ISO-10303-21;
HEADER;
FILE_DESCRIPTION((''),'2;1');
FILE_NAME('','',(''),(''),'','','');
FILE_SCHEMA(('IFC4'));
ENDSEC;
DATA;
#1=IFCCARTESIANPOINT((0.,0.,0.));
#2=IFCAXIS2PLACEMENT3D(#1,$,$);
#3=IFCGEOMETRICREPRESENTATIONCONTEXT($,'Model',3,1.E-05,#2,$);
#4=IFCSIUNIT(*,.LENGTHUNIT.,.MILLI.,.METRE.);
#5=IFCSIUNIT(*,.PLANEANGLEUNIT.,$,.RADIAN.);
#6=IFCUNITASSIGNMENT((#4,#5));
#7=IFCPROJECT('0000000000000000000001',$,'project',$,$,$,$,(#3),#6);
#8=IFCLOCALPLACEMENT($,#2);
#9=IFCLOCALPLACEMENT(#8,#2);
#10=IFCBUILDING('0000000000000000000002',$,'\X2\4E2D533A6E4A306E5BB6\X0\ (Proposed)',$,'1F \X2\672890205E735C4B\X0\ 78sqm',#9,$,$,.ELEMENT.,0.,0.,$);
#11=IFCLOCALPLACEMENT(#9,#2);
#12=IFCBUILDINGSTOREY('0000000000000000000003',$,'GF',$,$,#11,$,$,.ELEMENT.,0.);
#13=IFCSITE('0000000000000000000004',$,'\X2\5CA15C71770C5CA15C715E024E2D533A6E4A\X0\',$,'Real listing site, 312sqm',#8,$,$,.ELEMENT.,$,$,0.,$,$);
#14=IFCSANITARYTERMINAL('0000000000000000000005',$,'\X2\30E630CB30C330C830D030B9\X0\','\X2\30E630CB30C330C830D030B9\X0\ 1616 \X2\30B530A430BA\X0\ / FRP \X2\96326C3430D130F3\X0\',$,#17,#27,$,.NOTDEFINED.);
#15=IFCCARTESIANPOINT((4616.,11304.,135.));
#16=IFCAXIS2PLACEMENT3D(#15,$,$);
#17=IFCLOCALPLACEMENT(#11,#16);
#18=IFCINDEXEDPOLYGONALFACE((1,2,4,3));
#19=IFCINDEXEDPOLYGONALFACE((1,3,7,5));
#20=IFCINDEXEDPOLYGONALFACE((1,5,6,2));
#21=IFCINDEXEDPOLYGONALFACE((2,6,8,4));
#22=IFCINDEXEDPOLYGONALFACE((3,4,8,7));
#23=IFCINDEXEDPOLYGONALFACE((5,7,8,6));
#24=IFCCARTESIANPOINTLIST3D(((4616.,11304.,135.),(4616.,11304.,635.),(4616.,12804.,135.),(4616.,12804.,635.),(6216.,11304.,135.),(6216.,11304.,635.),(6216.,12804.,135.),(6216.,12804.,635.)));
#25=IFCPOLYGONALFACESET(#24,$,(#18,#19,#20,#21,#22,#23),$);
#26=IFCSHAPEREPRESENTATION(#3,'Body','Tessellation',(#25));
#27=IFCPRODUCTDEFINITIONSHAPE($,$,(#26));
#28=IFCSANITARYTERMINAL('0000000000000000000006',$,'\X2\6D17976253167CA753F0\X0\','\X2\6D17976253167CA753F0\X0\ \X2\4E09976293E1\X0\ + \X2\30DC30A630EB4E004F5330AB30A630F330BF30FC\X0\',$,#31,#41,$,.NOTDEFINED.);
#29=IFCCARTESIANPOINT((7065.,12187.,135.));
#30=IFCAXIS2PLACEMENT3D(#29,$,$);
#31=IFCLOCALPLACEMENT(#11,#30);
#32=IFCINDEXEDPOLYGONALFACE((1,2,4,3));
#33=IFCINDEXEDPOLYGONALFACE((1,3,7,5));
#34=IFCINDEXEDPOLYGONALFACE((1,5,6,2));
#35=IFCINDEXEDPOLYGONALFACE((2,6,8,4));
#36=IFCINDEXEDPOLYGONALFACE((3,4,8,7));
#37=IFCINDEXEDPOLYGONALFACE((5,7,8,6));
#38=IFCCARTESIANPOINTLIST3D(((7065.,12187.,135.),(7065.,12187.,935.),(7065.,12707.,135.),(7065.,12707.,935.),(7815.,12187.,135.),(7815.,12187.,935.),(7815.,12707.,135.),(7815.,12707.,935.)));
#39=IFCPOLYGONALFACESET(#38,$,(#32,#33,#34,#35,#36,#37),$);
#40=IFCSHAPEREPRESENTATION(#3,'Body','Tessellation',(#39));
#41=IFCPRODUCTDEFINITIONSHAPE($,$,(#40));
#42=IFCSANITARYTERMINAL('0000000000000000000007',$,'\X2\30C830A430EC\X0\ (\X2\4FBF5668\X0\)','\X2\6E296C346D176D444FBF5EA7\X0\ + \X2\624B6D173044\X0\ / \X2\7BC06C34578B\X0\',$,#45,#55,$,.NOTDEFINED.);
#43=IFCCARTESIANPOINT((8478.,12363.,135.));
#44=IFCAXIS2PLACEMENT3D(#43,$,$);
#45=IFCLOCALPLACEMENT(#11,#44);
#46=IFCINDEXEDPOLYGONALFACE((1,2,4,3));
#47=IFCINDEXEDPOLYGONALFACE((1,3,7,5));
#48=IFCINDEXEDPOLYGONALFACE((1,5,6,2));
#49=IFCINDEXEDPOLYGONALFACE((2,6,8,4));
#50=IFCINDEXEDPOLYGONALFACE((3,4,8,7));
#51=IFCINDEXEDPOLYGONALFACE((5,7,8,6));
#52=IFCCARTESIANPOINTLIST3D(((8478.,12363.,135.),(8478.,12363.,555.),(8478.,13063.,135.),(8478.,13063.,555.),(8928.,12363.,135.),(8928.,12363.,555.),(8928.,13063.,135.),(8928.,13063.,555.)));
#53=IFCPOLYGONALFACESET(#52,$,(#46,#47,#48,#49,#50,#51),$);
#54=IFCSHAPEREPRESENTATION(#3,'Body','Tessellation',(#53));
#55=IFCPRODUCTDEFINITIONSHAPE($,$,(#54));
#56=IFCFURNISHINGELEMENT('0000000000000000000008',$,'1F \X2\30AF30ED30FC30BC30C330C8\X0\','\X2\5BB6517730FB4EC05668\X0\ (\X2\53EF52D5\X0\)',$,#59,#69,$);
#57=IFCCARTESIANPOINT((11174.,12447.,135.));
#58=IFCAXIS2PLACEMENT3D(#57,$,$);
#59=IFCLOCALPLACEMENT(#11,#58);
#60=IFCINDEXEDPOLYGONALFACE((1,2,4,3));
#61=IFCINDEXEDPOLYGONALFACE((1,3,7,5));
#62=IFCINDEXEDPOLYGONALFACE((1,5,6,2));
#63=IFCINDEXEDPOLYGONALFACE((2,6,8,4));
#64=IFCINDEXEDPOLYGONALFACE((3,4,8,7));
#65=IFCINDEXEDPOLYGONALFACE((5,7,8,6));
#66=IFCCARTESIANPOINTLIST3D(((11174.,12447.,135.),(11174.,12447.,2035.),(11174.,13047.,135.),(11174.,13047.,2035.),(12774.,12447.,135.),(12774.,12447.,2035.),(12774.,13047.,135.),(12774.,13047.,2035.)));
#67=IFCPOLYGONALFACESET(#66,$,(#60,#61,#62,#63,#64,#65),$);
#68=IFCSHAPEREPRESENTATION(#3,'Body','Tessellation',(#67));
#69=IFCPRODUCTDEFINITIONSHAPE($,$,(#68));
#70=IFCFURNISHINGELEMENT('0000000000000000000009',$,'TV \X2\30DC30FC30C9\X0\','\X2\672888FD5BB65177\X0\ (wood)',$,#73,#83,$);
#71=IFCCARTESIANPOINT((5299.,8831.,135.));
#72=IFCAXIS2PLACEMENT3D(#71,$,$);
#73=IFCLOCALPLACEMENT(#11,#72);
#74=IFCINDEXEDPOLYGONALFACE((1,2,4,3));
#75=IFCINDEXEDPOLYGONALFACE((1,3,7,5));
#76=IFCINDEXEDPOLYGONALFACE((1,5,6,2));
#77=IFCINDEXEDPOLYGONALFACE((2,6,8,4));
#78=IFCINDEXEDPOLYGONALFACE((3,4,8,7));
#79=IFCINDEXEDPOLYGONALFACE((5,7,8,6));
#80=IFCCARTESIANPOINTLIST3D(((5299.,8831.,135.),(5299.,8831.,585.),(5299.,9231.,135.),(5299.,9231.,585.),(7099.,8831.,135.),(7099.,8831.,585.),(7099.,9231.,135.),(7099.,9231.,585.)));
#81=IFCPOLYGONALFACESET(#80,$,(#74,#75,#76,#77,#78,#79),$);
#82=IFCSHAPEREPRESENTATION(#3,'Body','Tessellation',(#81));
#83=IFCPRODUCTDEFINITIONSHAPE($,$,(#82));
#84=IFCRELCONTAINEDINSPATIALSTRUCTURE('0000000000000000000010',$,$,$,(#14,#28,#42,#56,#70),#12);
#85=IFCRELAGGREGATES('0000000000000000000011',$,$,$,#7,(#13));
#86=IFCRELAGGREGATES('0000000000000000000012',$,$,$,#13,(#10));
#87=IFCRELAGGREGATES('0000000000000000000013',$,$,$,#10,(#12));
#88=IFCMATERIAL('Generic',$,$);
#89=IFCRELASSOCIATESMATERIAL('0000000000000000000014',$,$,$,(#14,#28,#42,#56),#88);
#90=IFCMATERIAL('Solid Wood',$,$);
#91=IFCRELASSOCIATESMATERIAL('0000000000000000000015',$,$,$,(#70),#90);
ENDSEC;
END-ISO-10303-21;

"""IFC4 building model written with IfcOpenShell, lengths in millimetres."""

from ifc_helpers import new_model, si_unit, frame, frame_2d, origin, place, context, project, spatial, rectangle, extrude, material, element, save


model = new_model("IFC4")

# Units and contexts
model_context = context("Model", 3, precision=1e-05, world=origin())
ifc_project = project(units=[si_unit("LENGTHUNIT", "METRE", prefix="MILLI"), si_unit("PLANEANGLEUNIT", "RADIAN")], contexts=[model_context])

# Site, building, storey
site_placement = place(None, origin())
site = spatial("IfcSite", under=ifc_project, at=site_placement, Name="岡山県岡山市中区湊", ObjectType="Real listing site, 312sqm", CompositionType="ELEMENT", RefElevation=0.0)
building_placement = place(site_placement, origin())
building = spatial("IfcBuilding", under=site, at=building_placement, Name="中区湊の家 (Proposed)", ObjectType="1F 木造平屋 78sqm", CompositionType="ELEMENT", ElevationOfRefHeight=0.0, ElevationOfTerrain=0.0)
storey_placement = place(building_placement, origin())
storey = spatial("IfcBuildingStorey", under=building, at=storey_placement, Name="GF", CompositionType="ELEMENT", Elevation=0.0)

# Shared definitions
ifc_material_1 = material(Name="Solid Wood")

# Sanitary terminals
ifc_material_2 = material(Name="Generic")
sanitary_terminal_1_placement = place(storey_placement, frame((4616.0, 11304.0, 135.0)))
element("IfcSanitaryTerminal", 1, at=sanitary_terminal_1_placement, inside=storey, material=ifc_material_2, Name="ユニットバス", Description="ユニットバス 1616 サイズ / FRP 防水パン", PredefinedType="NOTDEFINED", context=model_context, shape_type="SweptSolid", body=[
    extrude(rectangle(XDim=1600.0, YDim=1500.0, at=frame_2d((800.0, 750.0))), frame((4616.0, 11304.0, 135.0)), (0.0, 0.0, 1.0), 500.0),
])
sanitary_terminal_2_placement = place(storey_placement, frame((7065.0, 12187.0, 135.0)))
element("IfcSanitaryTerminal", 2, at=sanitary_terminal_2_placement, inside=storey, material=ifc_material_2, Name="洗面化粧台", Description="洗面化粧台 三面鏡 + ボウル一体カウンター", PredefinedType="NOTDEFINED", context=model_context, shape_type="SweptSolid", body=[
    extrude(rectangle(XDim=750.0, YDim=520.0, at=frame_2d((375.0, 260.0))), frame((7065.0, 12187.0, 135.0)), (0.0, 0.0, 1.0), 800.0),
])
sanitary_terminal_3_placement = place(storey_placement, frame((8478.0, 12363.0, 135.0)))
element("IfcSanitaryTerminal", 3, at=sanitary_terminal_3_placement, inside=storey, material=ifc_material_2, Name="トイレ (便器)", Description="温水洗浄便座 + 手洗い / 節水型", PredefinedType="NOTDEFINED", context=model_context, shape_type="SweptSolid", body=[
    extrude(rectangle(XDim=450.0, YDim=700.0, at=frame_2d((225.0, 350.0))), frame((8478.0, 12363.0, 135.0)), (0.0, 0.0, 1.0), 420.0),
])

# Furnishing elements
furnishing_1_placement = place(storey_placement, frame((11174.0, 12447.0, 135.0)))
element("IfcFurnishingElement", 4, at=furnishing_1_placement, inside=storey, material=ifc_material_2, Name="1F クローゼット", Description="家具・什器 (可動)", context=model_context, shape_type="SweptSolid", body=[
    extrude(rectangle(XDim=1600.0, YDim=600.0, at=frame_2d((800.0, 300.0))), frame((11174.0, 12447.0, 135.0)), (0.0, 0.0, 1.0), 1900.0),
])
furnishing_2_placement = place(storey_placement, frame((5299.0, 8831.0, 135.0)))
element("IfcFurnishingElement", 5, at=furnishing_2_placement, inside=storey, material=ifc_material_1, Name="TV ボード", Description="木製家具 (wood)", context=model_context, shape_type="SweptSolid", body=[
    extrude(rectangle(XDim=1800.0, YDim=400.0, at=frame_2d((900.0, 200.0))), frame((5299.0, 8831.0, 135.0)), (0.0, 0.0, 1.0), 450.0),
])

save(model, "model.ifc")
